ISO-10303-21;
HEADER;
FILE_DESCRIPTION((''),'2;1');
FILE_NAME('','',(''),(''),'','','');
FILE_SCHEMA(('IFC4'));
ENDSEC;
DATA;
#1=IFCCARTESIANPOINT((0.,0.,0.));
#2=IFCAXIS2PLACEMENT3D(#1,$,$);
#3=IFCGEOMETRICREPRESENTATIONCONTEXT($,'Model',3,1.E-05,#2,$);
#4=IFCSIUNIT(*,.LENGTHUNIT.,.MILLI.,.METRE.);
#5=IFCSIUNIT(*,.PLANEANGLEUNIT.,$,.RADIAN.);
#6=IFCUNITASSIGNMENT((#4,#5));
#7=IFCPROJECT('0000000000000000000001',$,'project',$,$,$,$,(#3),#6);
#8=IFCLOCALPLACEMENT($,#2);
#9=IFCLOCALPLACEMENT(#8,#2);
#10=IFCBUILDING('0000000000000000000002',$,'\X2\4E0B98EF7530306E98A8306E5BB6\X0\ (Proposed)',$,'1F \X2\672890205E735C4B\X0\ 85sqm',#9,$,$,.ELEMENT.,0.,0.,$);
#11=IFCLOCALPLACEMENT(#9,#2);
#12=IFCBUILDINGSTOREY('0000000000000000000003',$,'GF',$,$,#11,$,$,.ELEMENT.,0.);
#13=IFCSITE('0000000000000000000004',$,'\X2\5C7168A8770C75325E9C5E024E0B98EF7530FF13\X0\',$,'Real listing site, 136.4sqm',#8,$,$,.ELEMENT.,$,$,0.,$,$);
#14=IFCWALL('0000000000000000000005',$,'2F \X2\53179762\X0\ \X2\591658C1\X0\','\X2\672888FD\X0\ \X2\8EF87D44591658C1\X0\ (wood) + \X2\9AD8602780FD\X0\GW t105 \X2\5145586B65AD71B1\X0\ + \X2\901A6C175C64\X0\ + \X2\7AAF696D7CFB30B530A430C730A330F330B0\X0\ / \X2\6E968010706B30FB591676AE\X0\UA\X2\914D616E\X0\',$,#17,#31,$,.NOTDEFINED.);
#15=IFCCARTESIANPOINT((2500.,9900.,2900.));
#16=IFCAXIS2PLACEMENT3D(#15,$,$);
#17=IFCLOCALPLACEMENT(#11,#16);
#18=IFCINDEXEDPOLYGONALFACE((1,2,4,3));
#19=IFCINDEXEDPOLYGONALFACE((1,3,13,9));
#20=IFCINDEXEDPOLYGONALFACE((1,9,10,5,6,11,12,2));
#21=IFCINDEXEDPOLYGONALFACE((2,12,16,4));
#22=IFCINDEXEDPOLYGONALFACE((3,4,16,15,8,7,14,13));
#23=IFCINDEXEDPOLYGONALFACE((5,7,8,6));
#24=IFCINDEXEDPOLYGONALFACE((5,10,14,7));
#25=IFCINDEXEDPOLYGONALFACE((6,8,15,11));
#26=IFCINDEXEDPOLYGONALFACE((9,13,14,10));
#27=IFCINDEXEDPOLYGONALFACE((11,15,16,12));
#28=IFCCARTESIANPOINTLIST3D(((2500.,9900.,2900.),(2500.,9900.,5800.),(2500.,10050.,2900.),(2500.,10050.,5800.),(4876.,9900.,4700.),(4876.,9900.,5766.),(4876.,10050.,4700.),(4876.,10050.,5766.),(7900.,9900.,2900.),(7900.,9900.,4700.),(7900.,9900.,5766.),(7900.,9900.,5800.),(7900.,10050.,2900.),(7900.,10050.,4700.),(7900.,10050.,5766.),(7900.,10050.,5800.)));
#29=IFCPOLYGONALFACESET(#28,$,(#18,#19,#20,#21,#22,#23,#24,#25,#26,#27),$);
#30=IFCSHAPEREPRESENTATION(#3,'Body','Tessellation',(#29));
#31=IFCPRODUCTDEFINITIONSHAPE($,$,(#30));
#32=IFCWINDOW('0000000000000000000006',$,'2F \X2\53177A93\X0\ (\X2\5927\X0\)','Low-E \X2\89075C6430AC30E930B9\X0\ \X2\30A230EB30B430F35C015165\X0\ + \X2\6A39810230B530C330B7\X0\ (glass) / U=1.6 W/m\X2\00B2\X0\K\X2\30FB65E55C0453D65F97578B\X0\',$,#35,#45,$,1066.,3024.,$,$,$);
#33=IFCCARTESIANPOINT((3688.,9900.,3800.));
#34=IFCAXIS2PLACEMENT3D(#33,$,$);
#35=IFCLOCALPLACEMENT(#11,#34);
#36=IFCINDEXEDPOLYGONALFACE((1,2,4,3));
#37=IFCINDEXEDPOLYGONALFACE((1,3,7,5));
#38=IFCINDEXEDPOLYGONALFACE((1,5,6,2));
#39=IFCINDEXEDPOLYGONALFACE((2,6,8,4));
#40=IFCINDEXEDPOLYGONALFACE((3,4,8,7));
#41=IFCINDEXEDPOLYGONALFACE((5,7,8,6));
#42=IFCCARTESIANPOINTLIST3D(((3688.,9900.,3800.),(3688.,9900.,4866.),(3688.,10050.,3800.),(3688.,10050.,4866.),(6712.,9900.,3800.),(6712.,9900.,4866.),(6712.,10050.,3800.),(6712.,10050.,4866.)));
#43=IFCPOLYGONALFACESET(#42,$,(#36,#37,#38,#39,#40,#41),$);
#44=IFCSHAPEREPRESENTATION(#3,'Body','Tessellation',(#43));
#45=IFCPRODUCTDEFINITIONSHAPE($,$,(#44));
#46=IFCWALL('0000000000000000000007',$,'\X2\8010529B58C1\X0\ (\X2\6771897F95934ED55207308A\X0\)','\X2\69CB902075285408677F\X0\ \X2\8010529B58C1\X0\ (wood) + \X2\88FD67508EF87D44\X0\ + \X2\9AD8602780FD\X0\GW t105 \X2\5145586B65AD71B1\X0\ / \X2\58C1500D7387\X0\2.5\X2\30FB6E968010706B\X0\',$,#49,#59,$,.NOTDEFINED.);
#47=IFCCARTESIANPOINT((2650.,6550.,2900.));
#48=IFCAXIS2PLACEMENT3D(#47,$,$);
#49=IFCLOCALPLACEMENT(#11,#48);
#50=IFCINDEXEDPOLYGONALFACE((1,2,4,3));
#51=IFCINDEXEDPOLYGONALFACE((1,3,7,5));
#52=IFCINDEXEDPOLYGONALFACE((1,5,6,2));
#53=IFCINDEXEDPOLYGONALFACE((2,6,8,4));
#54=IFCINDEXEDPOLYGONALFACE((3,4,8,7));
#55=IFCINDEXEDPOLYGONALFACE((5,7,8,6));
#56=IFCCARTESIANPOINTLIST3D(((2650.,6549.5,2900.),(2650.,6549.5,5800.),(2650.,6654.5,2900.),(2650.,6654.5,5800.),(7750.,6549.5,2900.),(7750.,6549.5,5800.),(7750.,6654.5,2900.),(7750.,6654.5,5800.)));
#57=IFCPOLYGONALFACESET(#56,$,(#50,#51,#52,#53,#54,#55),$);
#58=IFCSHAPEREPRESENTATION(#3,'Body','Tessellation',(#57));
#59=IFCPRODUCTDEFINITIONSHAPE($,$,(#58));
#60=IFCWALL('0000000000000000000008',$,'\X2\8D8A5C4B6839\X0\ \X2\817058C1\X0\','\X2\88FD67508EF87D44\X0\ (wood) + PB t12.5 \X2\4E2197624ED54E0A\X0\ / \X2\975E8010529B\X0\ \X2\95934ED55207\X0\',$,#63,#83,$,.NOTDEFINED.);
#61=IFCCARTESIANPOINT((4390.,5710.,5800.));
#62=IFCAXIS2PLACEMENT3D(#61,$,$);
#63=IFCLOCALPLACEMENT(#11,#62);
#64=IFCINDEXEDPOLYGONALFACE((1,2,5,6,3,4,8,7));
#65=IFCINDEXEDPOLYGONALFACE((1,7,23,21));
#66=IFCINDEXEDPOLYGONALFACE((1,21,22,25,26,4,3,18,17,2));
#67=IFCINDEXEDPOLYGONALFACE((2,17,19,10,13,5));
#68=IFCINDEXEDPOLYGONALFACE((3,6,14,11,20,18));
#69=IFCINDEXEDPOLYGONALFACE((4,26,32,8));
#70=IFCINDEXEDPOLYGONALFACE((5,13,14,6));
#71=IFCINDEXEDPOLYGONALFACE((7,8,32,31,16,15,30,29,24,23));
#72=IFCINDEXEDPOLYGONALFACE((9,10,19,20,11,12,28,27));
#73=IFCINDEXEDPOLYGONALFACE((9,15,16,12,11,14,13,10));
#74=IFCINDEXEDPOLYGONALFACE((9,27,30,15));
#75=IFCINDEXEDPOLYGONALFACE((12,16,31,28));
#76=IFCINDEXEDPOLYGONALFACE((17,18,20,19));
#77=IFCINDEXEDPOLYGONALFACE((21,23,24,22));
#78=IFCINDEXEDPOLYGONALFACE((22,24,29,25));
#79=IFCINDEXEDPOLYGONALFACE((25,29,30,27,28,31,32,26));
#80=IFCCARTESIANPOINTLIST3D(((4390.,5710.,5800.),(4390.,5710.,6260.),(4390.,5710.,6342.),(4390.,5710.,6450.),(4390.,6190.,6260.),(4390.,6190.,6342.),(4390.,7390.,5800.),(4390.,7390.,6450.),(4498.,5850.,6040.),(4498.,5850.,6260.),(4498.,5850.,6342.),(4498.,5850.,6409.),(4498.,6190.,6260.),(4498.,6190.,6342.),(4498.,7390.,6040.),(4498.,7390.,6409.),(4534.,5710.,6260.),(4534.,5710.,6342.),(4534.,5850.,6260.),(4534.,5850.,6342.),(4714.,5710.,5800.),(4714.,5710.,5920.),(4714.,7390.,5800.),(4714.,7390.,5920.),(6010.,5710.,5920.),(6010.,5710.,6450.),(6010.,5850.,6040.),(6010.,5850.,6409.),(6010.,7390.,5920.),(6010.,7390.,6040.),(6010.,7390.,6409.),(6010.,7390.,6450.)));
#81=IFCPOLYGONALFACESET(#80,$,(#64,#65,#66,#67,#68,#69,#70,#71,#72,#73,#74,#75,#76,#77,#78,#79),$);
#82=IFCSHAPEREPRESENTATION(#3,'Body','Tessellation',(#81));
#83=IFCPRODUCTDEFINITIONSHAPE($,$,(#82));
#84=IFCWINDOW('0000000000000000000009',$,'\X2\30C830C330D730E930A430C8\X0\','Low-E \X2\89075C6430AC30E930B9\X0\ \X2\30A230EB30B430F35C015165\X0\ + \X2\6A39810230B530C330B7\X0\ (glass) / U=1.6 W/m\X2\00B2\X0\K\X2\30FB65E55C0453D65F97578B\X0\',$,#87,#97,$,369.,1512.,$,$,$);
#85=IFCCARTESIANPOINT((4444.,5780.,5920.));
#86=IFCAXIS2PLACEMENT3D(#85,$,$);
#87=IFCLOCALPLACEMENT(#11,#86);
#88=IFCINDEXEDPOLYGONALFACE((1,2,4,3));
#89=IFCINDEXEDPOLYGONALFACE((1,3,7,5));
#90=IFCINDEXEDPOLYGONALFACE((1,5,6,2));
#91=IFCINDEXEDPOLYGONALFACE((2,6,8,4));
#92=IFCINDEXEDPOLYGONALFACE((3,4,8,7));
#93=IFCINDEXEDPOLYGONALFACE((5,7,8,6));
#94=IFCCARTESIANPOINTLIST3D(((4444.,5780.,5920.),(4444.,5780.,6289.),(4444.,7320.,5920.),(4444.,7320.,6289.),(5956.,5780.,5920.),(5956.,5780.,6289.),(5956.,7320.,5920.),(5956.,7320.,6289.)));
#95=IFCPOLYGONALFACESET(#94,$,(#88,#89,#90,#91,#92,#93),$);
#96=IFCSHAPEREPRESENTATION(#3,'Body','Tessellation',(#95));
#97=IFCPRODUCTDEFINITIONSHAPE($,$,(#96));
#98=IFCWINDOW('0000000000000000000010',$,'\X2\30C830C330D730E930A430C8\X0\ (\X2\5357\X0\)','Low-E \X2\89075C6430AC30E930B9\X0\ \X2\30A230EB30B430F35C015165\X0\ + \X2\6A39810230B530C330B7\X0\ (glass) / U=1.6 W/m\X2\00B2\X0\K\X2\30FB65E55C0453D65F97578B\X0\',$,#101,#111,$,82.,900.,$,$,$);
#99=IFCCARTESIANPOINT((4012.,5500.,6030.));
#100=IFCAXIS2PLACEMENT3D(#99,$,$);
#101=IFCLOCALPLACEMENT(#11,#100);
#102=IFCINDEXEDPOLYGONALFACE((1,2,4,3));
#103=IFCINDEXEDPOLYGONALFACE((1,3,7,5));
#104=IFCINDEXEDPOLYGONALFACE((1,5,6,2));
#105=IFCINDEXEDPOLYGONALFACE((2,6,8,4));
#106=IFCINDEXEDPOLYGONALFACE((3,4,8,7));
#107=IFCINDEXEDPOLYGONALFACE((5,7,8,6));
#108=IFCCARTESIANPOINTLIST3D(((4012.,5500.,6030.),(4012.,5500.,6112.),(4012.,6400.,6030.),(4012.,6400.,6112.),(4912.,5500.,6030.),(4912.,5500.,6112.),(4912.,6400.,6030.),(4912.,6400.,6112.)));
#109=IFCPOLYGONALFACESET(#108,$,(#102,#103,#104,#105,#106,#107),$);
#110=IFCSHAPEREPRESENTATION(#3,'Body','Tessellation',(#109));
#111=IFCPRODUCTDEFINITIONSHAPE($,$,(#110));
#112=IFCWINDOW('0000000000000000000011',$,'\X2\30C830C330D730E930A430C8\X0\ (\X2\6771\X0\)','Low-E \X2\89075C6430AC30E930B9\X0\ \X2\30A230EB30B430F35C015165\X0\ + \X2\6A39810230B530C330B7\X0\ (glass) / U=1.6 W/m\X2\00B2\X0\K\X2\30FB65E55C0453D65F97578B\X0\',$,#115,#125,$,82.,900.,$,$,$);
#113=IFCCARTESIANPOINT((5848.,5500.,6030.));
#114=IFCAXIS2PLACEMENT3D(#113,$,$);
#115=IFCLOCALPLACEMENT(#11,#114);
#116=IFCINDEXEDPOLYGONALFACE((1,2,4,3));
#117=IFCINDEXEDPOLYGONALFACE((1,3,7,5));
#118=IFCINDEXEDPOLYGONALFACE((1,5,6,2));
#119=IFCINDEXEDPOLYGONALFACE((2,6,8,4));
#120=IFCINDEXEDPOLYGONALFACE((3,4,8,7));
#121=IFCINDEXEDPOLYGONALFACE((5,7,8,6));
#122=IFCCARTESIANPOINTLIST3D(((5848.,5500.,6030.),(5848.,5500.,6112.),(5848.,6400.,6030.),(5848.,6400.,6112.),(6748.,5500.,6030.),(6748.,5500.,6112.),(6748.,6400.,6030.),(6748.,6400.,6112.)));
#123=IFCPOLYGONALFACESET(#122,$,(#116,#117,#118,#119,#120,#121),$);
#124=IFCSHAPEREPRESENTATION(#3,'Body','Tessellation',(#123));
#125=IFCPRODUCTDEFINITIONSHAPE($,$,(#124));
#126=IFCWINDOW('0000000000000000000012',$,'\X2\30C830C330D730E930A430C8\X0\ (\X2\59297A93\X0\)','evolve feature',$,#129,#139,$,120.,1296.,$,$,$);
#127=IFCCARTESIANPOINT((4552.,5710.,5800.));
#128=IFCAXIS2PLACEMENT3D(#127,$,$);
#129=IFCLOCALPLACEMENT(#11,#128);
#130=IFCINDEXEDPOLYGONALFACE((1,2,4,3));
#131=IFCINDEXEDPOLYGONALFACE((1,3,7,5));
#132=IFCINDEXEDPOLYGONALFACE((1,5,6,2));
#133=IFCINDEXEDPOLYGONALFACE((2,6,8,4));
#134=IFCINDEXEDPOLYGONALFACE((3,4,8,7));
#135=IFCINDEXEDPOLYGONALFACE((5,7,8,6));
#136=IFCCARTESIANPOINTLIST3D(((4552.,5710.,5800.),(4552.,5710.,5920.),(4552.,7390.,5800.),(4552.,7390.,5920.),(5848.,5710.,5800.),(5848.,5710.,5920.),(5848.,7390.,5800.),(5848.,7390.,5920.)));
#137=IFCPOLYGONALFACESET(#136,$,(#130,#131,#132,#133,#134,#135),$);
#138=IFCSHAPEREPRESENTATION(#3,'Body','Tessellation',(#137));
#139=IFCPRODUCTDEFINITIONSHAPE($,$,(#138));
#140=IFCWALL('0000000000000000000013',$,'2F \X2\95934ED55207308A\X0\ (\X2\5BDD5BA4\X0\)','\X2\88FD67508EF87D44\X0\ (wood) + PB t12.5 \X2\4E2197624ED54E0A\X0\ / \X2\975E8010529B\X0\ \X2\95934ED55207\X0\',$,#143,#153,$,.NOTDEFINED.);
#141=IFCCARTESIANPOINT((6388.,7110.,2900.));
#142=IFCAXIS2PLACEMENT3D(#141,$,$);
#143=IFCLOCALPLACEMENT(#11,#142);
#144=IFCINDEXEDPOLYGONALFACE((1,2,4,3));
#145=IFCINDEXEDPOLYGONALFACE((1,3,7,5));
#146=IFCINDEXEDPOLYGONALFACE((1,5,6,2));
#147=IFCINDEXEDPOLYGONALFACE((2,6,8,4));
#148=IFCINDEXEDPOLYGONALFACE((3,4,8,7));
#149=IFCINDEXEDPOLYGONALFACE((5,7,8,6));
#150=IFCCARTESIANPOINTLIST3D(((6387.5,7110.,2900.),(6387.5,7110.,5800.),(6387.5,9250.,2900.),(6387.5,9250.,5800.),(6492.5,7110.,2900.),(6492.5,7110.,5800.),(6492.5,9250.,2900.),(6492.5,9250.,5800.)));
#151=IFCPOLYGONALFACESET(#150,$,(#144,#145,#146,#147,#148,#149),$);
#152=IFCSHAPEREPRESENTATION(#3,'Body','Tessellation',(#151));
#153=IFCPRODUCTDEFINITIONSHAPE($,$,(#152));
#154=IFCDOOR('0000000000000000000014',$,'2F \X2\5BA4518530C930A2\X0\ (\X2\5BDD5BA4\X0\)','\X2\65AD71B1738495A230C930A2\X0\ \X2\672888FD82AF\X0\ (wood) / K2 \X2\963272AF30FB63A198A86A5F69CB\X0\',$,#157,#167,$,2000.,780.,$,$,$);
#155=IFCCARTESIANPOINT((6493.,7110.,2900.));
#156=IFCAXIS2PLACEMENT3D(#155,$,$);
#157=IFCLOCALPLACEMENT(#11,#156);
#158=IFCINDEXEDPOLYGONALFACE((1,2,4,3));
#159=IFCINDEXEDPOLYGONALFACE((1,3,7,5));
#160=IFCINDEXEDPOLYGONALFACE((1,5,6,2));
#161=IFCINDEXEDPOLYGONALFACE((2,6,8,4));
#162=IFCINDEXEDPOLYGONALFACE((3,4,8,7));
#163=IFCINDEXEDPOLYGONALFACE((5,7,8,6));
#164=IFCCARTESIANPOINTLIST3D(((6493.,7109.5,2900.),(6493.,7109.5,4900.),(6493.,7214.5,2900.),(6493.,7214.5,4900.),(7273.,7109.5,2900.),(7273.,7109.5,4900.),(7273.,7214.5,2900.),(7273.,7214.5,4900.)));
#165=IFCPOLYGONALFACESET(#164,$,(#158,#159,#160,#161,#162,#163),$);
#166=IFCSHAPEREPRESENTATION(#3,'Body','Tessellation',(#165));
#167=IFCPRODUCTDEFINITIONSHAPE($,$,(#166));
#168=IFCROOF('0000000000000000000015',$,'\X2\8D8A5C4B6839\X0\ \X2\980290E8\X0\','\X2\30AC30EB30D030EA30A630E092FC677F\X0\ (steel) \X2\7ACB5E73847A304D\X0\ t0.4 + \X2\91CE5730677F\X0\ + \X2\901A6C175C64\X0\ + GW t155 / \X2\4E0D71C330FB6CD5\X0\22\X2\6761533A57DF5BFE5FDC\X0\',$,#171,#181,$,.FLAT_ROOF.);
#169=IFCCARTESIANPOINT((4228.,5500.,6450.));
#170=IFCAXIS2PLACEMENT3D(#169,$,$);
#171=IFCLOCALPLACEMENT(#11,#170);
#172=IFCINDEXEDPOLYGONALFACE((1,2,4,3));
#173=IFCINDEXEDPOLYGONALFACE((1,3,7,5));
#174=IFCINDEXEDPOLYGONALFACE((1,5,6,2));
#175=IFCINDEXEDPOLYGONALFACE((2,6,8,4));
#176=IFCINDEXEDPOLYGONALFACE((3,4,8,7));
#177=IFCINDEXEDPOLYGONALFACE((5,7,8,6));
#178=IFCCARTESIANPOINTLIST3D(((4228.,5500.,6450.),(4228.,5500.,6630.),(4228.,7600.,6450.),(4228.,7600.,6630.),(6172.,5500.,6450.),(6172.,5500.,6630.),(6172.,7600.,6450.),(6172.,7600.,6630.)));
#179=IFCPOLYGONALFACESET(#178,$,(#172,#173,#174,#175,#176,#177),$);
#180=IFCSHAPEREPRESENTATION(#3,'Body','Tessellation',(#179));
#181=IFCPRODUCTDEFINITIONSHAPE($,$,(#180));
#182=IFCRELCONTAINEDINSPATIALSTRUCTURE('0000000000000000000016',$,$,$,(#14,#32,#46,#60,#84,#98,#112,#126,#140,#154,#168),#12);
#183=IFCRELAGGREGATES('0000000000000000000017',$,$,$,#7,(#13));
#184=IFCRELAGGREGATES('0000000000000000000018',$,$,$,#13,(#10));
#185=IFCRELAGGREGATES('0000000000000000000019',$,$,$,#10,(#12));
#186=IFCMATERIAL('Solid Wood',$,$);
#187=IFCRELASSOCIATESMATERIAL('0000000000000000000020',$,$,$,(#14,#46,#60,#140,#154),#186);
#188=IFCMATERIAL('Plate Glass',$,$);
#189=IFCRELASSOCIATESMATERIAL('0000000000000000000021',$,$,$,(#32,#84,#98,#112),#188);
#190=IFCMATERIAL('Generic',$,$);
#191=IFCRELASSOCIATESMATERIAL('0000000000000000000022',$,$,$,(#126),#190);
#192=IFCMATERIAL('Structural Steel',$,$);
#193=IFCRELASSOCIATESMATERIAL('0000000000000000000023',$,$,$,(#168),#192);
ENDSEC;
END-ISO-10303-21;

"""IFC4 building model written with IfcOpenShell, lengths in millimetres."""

from ifc_helpers import new_model, si_unit, frame, frame_2d, origin, place, context, project, spatial, rectangle, extrude, material, element, fill, save


model = new_model("IFC4")

# Units and contexts
model_context = context("Model", 3, precision=1e-05, world=origin())
ifc_project = project(units=[si_unit("LENGTHUNIT", "METRE", prefix="MILLI"), si_unit("PLANEANGLEUNIT", "RADIAN")], contexts=[model_context])

# Site, building, storey
site_placement = place(None, origin())
site = spatial("IfcSite", under=ifc_project, at=site_placement, Name="山梨県甲府市下飯田３", ObjectType="Real listing site, 136.4sqm", CompositionType="ELEMENT", RefElevation=0.0)
building_placement = place(site_placement, origin())
building = spatial("IfcBuilding", under=site, at=building_placement, Name="下飯田の風の家 (Proposed)", ObjectType="1F 木造平屋 85sqm", CompositionType="ELEMENT", ElevationOfRefHeight=0.0, ElevationOfTerrain=0.0)
storey_placement = place(building_placement, origin())
storey = spatial("IfcBuildingStorey", under=building, at=storey_placement, Name="GF", CompositionType="ELEMENT", Elevation=0.0)

# Wall, opening, window
ifc_material_1 = material(Name="Solid Wood")
wall_1_placement = place(storey_placement, frame((2500.0, 9900.0, 2900.0)))
wall_1 = element("IfcWall", 1, at=wall_1_placement, inside=storey, material=ifc_material_1, Name="2F 北面 外壁", Description="木製 軸組外壁 (wood) + 高性能GW t105 充填断熱 + 通気層 + 窯業系サイディング / 準耐火・外皮UA配慮", PredefinedType="NOTDEFINED", context=model_context, shape_type="SweptSolid", body=[
    extrude(rectangle(XDim=5400.0, YDim=150.0, at=frame_2d((2700.0, 75.0))), frame((2500.0, 9900.0, 2900.0)), (0.0, 0.0, 1.0), 2900.0),
])
opening_1_placement = place(storey_placement, frame((3688.0, 9900.0, 3800.0)))
opening_1 = element("IfcOpeningElement", 2, at=opening_1_placement, cuts=wall_1, PredefinedType="NOTDEFINED", context=model_context, shape_type="SweptSolid", body=[
    extrude(rectangle(XDim=3024.0, YDim=150.0, at=frame_2d((1512.0, 75.0))), frame((3688.0, 9900.0, 3800.0)), (0.0, 0.0, 1.0), 1066.0),
])
ifc_material_2 = material(Name="Plate Glass")
window_1_placement = place(storey_placement, frame((3688.0, 9900.0, 3800.0)))
window_1 = element("IfcWindow", 3, at=window_1_placement, inside=storey, material=ifc_material_2, Name="2F 北窓 (大)", Description="Low-E 複層ガラス アルゴン封入 + 樹脂サッシ (glass) / U=1.6 W/m²K・日射取得型", OverallHeight=1066.0, OverallWidth=3024.0, context=model_context, shape_type="SweptSolid", body=[
    extrude(rectangle(XDim=3024.0, YDim=150.0, at=frame_2d((1512.0, 75.0))), frame((3688.0, 9900.0, 3800.0)), (0.0, 0.0, 1.0), 1066.0),
])
fill(opening_1, window_1)

# Wall
wall_2_placement = place(storey_placement, frame((2650.0, 6550.0, 2900.0)))
element("IfcWall", 4, at=wall_2_placement, inside=storey, material=ifc_material_1, Name="耐力壁 (東西間仕切り)", Description="構造用合板 耐力壁 (wood) + 製材軸組 + 高性能GW t105 充填断熱 / 壁倍率2.5・準耐火", PredefinedType="NOTDEFINED", context=model_context, shape_type="SweptSolid", body=[
    extrude(rectangle(XDim=5100.0, YDim=105.0, at=frame_2d((2550.0, 52.0))), frame((2650.0, 6550.0, 2900.0)), (0.0, 0.0, 1.0), 2900.0),
])

# Wall, openings, windows
wall_3_placement = place(storey_placement, frame((4390.0, 5710.0, 5800.0)))
wall_3 = element("IfcWall", 5, at=wall_3_placement, inside=storey, material=ifc_material_1, Name="越屋根 腰壁", Description="製材軸組 (wood) + PB t12.5 両面仕上 / 非耐力 間仕切", PredefinedType="NOTDEFINED", context=model_context, shape_type="SweptSolid", body=[
    extrude(rectangle(XDim=1620.0, YDim=1680.0, at=frame_2d((810.0, 840.0))), frame((4390.0, 5710.0, 5800.0)), (0.0, 0.0, 1.0), 650.0),
])
opening_2_placement = place(storey_placement, frame((4444.0, 5780.0, 5920.0)))
opening_2 = element("IfcOpeningElement", 6, at=opening_2_placement, cuts=wall_3, PredefinedType="NOTDEFINED", context=model_context, shape_type="SweptSolid", body=[
    extrude(rectangle(XDim=1512.0, YDim=1540.0, at=frame_2d((756.0, 770.0))), frame((4444.0, 5780.0, 5920.0)), (0.0, 0.0, 1.0), 369.0),
])
opening_3_placement = place(storey_placement, frame((4012.0, 5500.0, 6030.0)))
opening_3 = element("IfcOpeningElement", 7, at=opening_3_placement, cuts=wall_3, PredefinedType="NOTDEFINED", context=model_context, shape_type="SweptSolid", body=[
    extrude(rectangle(XDim=900.0, YDim=900.0, at=frame_2d((450.0, 450.0))), frame((4012.0, 5500.0, 6030.0)), (0.0, 0.0, 1.0), 82.0),
])
opening_4_placement = place(storey_placement, frame((5848.0, 5500.0, 6030.0)))
opening_4 = element("IfcOpeningElement", 8, at=opening_4_placement, cuts=wall_3, PredefinedType="NOTDEFINED", context=model_context, shape_type="SweptSolid", body=[
    extrude(rectangle(XDim=900.0, YDim=900.0, at=frame_2d((450.0, 450.0))), frame((5848.0, 5500.0, 6030.0)), (0.0, 0.0, 1.0), 82.0),
])
opening_5_placement = place(storey_placement, frame((4552.0, 5710.0, 5800.0)))
opening_5 = element("IfcOpeningElement", 9, at=opening_5_placement, cuts=wall_3, PredefinedType="NOTDEFINED", context=model_context, shape_type="SweptSolid", body=[
    extrude(rectangle(XDim=1296.0, YDim=1680.0, at=frame_2d((648.0, 840.0))), frame((4552.0, 5710.0, 5800.0)), (0.0, 0.0, 1.0), 120.0),
])
window_2_placement = place(storey_placement, frame((4444.0, 5780.0, 5920.0)))
window_2 = element("IfcWindow", 10, at=window_2_placement, inside=storey, material=ifc_material_2, Name="トップライト", Description="Low-E 複層ガラス アルゴン封入 + 樹脂サッシ (glass) / U=1.6 W/m²K・日射取得型", OverallHeight=369.0, OverallWidth=1512.0, context=model_context, shape_type="SweptSolid", body=[
    extrude(rectangle(XDim=1512.0, YDim=1540.0, at=frame_2d((756.0, 770.0))), frame((4444.0, 5780.0, 5920.0)), (0.0, 0.0, 1.0), 369.0),
])
fill(opening_2, window_2)
window_3_placement = place(storey_placement, frame((4012.0, 5500.0, 6030.0)))
window_3 = element("IfcWindow", 11, at=window_3_placement, inside=storey, material=ifc_material_2, Name="トップライト (南)", Description="Low-E 複層ガラス アルゴン封入 + 樹脂サッシ (glass) / U=1.6 W/m²K・日射取得型", OverallHeight=82.0, OverallWidth=900.0, context=model_context, shape_type="SweptSolid", body=[
    extrude(rectangle(XDim=900.0, YDim=900.0, at=frame_2d((450.0, 450.0))), frame((4012.0, 5500.0, 6030.0)), (0.0, 0.0, 1.0), 82.0),
])
fill(opening_3, window_3)
window_4_placement = place(storey_placement, frame((5848.0, 5500.0, 6030.0)))
window_4 = element("IfcWindow", 12, at=window_4_placement, inside=storey, material=ifc_material_2, Name="トップライト (東)", Description="Low-E 複層ガラス アルゴン封入 + 樹脂サッシ (glass) / U=1.6 W/m²K・日射取得型", OverallHeight=82.0, OverallWidth=900.0, context=model_context, shape_type="SweptSolid", body=[
    extrude(rectangle(XDim=900.0, YDim=900.0, at=frame_2d((450.0, 450.0))), frame((5848.0, 5500.0, 6030.0)), (0.0, 0.0, 1.0), 82.0),
])
fill(opening_4, window_4)
ifc_material_3 = material(Name="Generic")
window_5_placement = place(storey_placement, frame((4552.0, 5710.0, 5800.0)))
window_5 = element("IfcWindow", 13, at=window_5_placement, inside=storey, material=ifc_material_3, Name="トップライト (天窓)", Description="evolve feature", OverallHeight=120.0, OverallWidth=1296.0, context=model_context, shape_type="SweptSolid", body=[
    extrude(rectangle(XDim=1296.0, YDim=1680.0, at=frame_2d((648.0, 840.0))), frame((4552.0, 5710.0, 5800.0)), (0.0, 0.0, 1.0), 120.0),
])
fill(opening_5, window_5)

# Wall
wall_4_placement = place(storey_placement, frame((6388.0, 7110.0, 2900.0)))
element("IfcWall", 14, at=wall_4_placement, inside=storey, material=ifc_material_1, Name="2F 間仕切り (寝室)", Description="製材軸組 (wood) + PB t12.5 両面仕上 / 非耐力 間仕切", PredefinedType="NOTDEFINED", context=model_context, shape_type="SweptSolid", body=[
    extrude(rectangle(XDim=105.0, YDim=2140.0, at=frame_2d((52.0, 1070.0))), frame((6388.0, 7110.0, 2900.0)), (0.0, 0.0, 1.0), 2900.0),
])

# Door
door_placement = place(storey_placement, frame((6493.0, 7110.0, 2900.0)))
element("IfcDoor", 15, at=door_placement, inside=storey, material=ifc_material_1, Name="2F 室内ドア (寝室)", Description="断熱玄関ドア 木製芯 (wood) / K2 防犯・採風機構", OverallHeight=2000.0, OverallWidth=780.0, context=model_context, shape_type="SweptSolid", body=[
    extrude(rectangle(XDim=780.0, YDim=105.0, at=frame_2d((390.0, 52.0))), frame((6493.0, 7110.0, 2900.0)), (0.0, 0.0, 1.0), 2000.0),
])

# Roof
ifc_material_4 = material(Name="Structural Steel")
roof_placement = place(storey_placement, frame((4228.0, 5500.0, 6450.0)))
element("IfcRoof", 16, at=roof_placement, inside=storey, material=ifc_material_4, Name="越屋根 頂部", Description="ガルバリウム鋼板 (steel) 立平葺き t0.4 + 野地板 + 通気層 + GW t155 / 不燃・法22条区域対応", PredefinedType="FLAT_ROOF", context=model_context, shape_type="SweptSolid", body=[
    extrude(rectangle(XDim=1944.0, YDim=2100.0, at=frame_2d((972.0, 1050.0))), frame((4228.0, 5500.0, 6450.0)), (0.0, 0.0, 1.0), 180.0),
])

save(model, "model.ifc")
